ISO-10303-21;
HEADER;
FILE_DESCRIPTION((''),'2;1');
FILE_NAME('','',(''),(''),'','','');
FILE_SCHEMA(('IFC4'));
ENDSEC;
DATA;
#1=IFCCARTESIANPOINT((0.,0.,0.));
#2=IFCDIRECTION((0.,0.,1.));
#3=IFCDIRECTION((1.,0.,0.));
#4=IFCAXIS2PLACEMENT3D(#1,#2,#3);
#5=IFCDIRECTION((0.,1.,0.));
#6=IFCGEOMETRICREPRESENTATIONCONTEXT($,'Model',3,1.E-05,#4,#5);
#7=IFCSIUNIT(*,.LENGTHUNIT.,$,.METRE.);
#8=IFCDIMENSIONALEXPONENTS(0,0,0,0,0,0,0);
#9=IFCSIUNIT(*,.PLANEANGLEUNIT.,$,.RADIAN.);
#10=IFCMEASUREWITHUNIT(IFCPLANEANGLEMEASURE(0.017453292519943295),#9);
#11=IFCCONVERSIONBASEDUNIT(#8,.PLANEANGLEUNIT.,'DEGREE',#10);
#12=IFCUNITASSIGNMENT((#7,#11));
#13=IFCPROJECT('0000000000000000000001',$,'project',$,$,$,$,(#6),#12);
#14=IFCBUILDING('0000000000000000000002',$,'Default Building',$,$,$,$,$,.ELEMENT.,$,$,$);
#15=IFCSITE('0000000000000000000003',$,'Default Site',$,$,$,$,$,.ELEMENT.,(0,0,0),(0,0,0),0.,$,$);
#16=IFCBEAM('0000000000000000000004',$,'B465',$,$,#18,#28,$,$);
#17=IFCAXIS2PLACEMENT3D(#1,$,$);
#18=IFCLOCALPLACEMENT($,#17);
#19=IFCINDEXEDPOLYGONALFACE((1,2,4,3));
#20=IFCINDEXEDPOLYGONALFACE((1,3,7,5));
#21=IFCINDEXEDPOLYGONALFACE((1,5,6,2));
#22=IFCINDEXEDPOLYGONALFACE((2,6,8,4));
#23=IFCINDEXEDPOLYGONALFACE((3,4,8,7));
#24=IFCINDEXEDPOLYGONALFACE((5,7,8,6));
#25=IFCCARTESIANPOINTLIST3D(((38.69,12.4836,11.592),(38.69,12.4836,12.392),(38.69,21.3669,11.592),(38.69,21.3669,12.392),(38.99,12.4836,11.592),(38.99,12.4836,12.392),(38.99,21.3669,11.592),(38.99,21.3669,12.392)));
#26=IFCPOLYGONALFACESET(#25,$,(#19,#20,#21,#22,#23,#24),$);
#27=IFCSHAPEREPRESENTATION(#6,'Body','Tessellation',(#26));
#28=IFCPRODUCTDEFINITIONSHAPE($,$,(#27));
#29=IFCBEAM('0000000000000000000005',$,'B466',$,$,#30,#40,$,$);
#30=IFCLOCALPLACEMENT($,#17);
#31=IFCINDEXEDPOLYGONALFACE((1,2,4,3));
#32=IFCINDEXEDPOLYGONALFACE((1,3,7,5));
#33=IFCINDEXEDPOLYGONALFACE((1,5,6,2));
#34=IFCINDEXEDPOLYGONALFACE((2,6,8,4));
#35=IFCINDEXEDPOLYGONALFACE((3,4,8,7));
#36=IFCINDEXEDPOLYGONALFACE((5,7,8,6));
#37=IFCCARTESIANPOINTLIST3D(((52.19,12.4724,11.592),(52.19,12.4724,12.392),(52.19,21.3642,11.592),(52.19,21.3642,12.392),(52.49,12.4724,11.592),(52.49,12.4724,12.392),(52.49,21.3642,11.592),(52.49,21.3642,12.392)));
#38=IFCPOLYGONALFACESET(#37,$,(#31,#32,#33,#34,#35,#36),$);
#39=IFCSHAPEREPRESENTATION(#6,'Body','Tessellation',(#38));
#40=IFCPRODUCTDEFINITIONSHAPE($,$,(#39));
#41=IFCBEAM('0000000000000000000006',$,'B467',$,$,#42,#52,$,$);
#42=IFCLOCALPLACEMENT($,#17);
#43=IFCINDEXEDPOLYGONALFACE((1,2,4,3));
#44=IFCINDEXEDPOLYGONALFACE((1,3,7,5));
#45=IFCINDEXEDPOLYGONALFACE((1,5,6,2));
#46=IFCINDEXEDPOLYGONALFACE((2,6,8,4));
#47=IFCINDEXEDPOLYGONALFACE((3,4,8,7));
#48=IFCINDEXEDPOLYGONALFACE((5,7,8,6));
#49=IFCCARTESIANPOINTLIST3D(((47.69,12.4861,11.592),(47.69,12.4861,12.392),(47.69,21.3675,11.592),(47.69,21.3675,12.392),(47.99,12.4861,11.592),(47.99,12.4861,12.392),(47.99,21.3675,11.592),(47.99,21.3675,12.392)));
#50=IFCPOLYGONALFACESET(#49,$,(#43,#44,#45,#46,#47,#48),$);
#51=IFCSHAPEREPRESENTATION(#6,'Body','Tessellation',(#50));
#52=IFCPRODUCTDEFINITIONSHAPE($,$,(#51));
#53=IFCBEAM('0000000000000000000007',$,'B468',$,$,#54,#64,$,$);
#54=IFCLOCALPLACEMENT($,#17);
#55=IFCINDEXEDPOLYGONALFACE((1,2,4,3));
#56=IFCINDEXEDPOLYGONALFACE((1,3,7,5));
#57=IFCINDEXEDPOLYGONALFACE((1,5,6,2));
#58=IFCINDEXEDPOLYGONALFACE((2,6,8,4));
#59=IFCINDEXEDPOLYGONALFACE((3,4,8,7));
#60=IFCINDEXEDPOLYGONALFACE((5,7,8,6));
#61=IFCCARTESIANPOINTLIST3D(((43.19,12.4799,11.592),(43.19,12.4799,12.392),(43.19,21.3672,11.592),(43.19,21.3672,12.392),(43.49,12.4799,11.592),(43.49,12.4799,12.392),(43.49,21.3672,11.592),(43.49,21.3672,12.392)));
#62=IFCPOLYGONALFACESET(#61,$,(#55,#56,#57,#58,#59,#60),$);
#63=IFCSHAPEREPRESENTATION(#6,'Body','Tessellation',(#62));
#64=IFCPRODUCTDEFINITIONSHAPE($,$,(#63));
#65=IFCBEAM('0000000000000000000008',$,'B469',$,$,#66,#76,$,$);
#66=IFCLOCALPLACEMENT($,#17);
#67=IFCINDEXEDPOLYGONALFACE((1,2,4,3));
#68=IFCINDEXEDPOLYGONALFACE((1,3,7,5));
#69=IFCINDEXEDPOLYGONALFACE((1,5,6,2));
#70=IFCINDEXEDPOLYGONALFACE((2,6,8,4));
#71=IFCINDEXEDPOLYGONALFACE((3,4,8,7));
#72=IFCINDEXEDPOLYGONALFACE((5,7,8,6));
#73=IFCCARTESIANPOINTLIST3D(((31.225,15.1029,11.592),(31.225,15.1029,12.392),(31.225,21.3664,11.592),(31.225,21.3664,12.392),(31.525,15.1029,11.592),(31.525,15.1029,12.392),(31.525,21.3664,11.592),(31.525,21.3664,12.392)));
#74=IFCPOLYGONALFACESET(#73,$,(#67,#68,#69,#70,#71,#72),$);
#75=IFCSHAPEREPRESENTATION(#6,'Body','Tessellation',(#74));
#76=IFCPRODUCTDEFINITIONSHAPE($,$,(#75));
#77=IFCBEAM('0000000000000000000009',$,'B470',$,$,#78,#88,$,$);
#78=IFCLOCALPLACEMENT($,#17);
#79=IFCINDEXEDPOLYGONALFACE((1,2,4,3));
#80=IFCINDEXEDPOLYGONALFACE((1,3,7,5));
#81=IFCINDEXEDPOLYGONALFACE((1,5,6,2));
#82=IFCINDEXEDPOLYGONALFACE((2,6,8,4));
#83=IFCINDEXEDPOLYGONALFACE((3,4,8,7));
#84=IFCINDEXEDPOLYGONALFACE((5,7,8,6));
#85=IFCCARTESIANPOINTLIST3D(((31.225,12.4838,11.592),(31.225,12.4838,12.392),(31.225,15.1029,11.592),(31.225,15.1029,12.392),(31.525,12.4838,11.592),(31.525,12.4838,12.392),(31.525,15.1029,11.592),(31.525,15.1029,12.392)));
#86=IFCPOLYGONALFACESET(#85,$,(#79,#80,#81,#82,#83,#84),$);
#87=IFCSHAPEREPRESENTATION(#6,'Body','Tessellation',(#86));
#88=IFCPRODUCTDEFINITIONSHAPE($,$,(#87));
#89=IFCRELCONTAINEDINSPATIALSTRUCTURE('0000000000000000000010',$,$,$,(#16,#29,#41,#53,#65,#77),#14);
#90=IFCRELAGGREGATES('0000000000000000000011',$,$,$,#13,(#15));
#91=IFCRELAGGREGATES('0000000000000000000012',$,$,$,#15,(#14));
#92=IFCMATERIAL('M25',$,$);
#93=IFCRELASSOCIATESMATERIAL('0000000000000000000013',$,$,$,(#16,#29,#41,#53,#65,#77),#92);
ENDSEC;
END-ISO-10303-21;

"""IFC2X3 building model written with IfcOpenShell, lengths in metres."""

from ifc_helpers import new_model, entity, si_unit, converted_unit, direction, frame, frame_2d, origin_with_axes, place, context, project, spatial, rectangle, extrude, material, element, save


model = new_model("IFC2X3")

# Units and contexts
model_context = context("Model", 3, precision=1e-05, world=origin_with_axes(), true_north=direction((0.0, 1.0, 0.0)))
ifc_project = project(units=[si_unit("LENGTHUNIT", "METRE"), converted_unit("PLANEANGLEUNIT", "DEGREE", entity("IfcPlaneAngleMeasure", 0.017453292519943295), si_unit("PLANEANGLEUNIT", "RADIAN"), dimensions=[0, 0, 0, 0, 0, 0, 0])], contexts=[model_context])

# Site, building
site = spatial("IfcSite", under=ifc_project, Name="Default Site", CompositionType="ELEMENT", RefLatitude=(0, 0, 0), RefLongitude=(0, 0, 0), RefElevation=0.0)
building = spatial("IfcBuilding", under=site, Name="Default Building", CompositionType="ELEMENT")

# Beams
ifc_material = material(Name="M25")
placement = place(None, origin_with_axes())
element("IfcBeam", 1, at=placement, inside=building, material=ifc_material, Name="B465", context=model_context, shape_type="SweptSolid", body=[
    extrude(rectangle(XDim=0.3, YDim=0.8, at=frame_2d((0.0, 0.0), x_axis=(0.0, 1.0, 0.0))), frame((38.84, 21.3669, 11.992), z_axis=(0.0, -1.0, 0.0), x_axis=(0.0, 0.0, -1.0)), (0.0, 0.0, 1.0), 8.8833),
])
element("IfcBeam", 2, at=placement, inside=building, material=ifc_material, Name="B466", context=model_context, shape_type="SweptSolid", body=[
    extrude(rectangle(XDim=0.3, YDim=0.8, at=frame_2d((0.0, 0.0), x_axis=(0.0, 1.0, 0.0))), frame((52.34, 12.4724, 11.992), z_axis=(0.0, 1.0, 0.0), x_axis=(0.0, 0.0, -1.0)), (0.0, 0.0, 1.0), 8.8918),
])
element("IfcBeam", 3, at=placement, inside=building, material=ifc_material, Name="B467", context=model_context, shape_type="SweptSolid", body=[
    extrude(rectangle(XDim=0.3, YDim=0.8, at=frame_2d((0.0, 0.0), x_axis=(0.0, 1.0, 0.0))), frame((47.84, 12.4861, 11.992), z_axis=(0.0, 1.0, 0.0), x_axis=(0.0, 0.0, -1.0)), (0.0, 0.0, 1.0), 8.8814),
])
element("IfcBeam", 4, at=placement, inside=building, material=ifc_material, Name="B468", context=model_context, shape_type="SweptSolid", body=[
    extrude(rectangle(XDim=0.3, YDim=0.8, at=frame_2d((0.0, 0.0), x_axis=(0.0, 1.0, 0.0))), frame((43.34, 21.3672, 11.992), z_axis=(0.0, -1.0, 0.0), x_axis=(0.0, 0.0, -1.0)), (0.0, 0.0, 1.0), 8.8873),
])
element("IfcBeam", 5, at=placement, inside=building, material=ifc_material, Name="B469", context=model_context, shape_type="SweptSolid", body=[
    extrude(rectangle(XDim=0.3, YDim=0.8, at=frame_2d((0.0, 0.0), x_axis=(0.0, 1.0, 0.0))), frame((31.375, 21.3664, 11.992), z_axis=(0.0, -1.0, 0.0), x_axis=(0.0, 0.0, -1.0)), (0.0, 0.0, 1.0), 6.2635),
])
element("IfcBeam", 6, at=placement, inside=building, material=ifc_material, Name="B470", context=model_context, shape_type="SweptSolid", body=[
    extrude(rectangle(XDim=0.3, YDim=0.8, at=frame_2d((0.0, 0.0), x_axis=(0.0, 1.0, 0.0))), frame((31.375, 15.1029, 11.992), z_axis=(0.0, -1.0, 0.0), x_axis=(0.0, 0.0, -1.0)), (0.0, 0.0, 1.0), 2.6191),
])

save(model, "model.ifc")
